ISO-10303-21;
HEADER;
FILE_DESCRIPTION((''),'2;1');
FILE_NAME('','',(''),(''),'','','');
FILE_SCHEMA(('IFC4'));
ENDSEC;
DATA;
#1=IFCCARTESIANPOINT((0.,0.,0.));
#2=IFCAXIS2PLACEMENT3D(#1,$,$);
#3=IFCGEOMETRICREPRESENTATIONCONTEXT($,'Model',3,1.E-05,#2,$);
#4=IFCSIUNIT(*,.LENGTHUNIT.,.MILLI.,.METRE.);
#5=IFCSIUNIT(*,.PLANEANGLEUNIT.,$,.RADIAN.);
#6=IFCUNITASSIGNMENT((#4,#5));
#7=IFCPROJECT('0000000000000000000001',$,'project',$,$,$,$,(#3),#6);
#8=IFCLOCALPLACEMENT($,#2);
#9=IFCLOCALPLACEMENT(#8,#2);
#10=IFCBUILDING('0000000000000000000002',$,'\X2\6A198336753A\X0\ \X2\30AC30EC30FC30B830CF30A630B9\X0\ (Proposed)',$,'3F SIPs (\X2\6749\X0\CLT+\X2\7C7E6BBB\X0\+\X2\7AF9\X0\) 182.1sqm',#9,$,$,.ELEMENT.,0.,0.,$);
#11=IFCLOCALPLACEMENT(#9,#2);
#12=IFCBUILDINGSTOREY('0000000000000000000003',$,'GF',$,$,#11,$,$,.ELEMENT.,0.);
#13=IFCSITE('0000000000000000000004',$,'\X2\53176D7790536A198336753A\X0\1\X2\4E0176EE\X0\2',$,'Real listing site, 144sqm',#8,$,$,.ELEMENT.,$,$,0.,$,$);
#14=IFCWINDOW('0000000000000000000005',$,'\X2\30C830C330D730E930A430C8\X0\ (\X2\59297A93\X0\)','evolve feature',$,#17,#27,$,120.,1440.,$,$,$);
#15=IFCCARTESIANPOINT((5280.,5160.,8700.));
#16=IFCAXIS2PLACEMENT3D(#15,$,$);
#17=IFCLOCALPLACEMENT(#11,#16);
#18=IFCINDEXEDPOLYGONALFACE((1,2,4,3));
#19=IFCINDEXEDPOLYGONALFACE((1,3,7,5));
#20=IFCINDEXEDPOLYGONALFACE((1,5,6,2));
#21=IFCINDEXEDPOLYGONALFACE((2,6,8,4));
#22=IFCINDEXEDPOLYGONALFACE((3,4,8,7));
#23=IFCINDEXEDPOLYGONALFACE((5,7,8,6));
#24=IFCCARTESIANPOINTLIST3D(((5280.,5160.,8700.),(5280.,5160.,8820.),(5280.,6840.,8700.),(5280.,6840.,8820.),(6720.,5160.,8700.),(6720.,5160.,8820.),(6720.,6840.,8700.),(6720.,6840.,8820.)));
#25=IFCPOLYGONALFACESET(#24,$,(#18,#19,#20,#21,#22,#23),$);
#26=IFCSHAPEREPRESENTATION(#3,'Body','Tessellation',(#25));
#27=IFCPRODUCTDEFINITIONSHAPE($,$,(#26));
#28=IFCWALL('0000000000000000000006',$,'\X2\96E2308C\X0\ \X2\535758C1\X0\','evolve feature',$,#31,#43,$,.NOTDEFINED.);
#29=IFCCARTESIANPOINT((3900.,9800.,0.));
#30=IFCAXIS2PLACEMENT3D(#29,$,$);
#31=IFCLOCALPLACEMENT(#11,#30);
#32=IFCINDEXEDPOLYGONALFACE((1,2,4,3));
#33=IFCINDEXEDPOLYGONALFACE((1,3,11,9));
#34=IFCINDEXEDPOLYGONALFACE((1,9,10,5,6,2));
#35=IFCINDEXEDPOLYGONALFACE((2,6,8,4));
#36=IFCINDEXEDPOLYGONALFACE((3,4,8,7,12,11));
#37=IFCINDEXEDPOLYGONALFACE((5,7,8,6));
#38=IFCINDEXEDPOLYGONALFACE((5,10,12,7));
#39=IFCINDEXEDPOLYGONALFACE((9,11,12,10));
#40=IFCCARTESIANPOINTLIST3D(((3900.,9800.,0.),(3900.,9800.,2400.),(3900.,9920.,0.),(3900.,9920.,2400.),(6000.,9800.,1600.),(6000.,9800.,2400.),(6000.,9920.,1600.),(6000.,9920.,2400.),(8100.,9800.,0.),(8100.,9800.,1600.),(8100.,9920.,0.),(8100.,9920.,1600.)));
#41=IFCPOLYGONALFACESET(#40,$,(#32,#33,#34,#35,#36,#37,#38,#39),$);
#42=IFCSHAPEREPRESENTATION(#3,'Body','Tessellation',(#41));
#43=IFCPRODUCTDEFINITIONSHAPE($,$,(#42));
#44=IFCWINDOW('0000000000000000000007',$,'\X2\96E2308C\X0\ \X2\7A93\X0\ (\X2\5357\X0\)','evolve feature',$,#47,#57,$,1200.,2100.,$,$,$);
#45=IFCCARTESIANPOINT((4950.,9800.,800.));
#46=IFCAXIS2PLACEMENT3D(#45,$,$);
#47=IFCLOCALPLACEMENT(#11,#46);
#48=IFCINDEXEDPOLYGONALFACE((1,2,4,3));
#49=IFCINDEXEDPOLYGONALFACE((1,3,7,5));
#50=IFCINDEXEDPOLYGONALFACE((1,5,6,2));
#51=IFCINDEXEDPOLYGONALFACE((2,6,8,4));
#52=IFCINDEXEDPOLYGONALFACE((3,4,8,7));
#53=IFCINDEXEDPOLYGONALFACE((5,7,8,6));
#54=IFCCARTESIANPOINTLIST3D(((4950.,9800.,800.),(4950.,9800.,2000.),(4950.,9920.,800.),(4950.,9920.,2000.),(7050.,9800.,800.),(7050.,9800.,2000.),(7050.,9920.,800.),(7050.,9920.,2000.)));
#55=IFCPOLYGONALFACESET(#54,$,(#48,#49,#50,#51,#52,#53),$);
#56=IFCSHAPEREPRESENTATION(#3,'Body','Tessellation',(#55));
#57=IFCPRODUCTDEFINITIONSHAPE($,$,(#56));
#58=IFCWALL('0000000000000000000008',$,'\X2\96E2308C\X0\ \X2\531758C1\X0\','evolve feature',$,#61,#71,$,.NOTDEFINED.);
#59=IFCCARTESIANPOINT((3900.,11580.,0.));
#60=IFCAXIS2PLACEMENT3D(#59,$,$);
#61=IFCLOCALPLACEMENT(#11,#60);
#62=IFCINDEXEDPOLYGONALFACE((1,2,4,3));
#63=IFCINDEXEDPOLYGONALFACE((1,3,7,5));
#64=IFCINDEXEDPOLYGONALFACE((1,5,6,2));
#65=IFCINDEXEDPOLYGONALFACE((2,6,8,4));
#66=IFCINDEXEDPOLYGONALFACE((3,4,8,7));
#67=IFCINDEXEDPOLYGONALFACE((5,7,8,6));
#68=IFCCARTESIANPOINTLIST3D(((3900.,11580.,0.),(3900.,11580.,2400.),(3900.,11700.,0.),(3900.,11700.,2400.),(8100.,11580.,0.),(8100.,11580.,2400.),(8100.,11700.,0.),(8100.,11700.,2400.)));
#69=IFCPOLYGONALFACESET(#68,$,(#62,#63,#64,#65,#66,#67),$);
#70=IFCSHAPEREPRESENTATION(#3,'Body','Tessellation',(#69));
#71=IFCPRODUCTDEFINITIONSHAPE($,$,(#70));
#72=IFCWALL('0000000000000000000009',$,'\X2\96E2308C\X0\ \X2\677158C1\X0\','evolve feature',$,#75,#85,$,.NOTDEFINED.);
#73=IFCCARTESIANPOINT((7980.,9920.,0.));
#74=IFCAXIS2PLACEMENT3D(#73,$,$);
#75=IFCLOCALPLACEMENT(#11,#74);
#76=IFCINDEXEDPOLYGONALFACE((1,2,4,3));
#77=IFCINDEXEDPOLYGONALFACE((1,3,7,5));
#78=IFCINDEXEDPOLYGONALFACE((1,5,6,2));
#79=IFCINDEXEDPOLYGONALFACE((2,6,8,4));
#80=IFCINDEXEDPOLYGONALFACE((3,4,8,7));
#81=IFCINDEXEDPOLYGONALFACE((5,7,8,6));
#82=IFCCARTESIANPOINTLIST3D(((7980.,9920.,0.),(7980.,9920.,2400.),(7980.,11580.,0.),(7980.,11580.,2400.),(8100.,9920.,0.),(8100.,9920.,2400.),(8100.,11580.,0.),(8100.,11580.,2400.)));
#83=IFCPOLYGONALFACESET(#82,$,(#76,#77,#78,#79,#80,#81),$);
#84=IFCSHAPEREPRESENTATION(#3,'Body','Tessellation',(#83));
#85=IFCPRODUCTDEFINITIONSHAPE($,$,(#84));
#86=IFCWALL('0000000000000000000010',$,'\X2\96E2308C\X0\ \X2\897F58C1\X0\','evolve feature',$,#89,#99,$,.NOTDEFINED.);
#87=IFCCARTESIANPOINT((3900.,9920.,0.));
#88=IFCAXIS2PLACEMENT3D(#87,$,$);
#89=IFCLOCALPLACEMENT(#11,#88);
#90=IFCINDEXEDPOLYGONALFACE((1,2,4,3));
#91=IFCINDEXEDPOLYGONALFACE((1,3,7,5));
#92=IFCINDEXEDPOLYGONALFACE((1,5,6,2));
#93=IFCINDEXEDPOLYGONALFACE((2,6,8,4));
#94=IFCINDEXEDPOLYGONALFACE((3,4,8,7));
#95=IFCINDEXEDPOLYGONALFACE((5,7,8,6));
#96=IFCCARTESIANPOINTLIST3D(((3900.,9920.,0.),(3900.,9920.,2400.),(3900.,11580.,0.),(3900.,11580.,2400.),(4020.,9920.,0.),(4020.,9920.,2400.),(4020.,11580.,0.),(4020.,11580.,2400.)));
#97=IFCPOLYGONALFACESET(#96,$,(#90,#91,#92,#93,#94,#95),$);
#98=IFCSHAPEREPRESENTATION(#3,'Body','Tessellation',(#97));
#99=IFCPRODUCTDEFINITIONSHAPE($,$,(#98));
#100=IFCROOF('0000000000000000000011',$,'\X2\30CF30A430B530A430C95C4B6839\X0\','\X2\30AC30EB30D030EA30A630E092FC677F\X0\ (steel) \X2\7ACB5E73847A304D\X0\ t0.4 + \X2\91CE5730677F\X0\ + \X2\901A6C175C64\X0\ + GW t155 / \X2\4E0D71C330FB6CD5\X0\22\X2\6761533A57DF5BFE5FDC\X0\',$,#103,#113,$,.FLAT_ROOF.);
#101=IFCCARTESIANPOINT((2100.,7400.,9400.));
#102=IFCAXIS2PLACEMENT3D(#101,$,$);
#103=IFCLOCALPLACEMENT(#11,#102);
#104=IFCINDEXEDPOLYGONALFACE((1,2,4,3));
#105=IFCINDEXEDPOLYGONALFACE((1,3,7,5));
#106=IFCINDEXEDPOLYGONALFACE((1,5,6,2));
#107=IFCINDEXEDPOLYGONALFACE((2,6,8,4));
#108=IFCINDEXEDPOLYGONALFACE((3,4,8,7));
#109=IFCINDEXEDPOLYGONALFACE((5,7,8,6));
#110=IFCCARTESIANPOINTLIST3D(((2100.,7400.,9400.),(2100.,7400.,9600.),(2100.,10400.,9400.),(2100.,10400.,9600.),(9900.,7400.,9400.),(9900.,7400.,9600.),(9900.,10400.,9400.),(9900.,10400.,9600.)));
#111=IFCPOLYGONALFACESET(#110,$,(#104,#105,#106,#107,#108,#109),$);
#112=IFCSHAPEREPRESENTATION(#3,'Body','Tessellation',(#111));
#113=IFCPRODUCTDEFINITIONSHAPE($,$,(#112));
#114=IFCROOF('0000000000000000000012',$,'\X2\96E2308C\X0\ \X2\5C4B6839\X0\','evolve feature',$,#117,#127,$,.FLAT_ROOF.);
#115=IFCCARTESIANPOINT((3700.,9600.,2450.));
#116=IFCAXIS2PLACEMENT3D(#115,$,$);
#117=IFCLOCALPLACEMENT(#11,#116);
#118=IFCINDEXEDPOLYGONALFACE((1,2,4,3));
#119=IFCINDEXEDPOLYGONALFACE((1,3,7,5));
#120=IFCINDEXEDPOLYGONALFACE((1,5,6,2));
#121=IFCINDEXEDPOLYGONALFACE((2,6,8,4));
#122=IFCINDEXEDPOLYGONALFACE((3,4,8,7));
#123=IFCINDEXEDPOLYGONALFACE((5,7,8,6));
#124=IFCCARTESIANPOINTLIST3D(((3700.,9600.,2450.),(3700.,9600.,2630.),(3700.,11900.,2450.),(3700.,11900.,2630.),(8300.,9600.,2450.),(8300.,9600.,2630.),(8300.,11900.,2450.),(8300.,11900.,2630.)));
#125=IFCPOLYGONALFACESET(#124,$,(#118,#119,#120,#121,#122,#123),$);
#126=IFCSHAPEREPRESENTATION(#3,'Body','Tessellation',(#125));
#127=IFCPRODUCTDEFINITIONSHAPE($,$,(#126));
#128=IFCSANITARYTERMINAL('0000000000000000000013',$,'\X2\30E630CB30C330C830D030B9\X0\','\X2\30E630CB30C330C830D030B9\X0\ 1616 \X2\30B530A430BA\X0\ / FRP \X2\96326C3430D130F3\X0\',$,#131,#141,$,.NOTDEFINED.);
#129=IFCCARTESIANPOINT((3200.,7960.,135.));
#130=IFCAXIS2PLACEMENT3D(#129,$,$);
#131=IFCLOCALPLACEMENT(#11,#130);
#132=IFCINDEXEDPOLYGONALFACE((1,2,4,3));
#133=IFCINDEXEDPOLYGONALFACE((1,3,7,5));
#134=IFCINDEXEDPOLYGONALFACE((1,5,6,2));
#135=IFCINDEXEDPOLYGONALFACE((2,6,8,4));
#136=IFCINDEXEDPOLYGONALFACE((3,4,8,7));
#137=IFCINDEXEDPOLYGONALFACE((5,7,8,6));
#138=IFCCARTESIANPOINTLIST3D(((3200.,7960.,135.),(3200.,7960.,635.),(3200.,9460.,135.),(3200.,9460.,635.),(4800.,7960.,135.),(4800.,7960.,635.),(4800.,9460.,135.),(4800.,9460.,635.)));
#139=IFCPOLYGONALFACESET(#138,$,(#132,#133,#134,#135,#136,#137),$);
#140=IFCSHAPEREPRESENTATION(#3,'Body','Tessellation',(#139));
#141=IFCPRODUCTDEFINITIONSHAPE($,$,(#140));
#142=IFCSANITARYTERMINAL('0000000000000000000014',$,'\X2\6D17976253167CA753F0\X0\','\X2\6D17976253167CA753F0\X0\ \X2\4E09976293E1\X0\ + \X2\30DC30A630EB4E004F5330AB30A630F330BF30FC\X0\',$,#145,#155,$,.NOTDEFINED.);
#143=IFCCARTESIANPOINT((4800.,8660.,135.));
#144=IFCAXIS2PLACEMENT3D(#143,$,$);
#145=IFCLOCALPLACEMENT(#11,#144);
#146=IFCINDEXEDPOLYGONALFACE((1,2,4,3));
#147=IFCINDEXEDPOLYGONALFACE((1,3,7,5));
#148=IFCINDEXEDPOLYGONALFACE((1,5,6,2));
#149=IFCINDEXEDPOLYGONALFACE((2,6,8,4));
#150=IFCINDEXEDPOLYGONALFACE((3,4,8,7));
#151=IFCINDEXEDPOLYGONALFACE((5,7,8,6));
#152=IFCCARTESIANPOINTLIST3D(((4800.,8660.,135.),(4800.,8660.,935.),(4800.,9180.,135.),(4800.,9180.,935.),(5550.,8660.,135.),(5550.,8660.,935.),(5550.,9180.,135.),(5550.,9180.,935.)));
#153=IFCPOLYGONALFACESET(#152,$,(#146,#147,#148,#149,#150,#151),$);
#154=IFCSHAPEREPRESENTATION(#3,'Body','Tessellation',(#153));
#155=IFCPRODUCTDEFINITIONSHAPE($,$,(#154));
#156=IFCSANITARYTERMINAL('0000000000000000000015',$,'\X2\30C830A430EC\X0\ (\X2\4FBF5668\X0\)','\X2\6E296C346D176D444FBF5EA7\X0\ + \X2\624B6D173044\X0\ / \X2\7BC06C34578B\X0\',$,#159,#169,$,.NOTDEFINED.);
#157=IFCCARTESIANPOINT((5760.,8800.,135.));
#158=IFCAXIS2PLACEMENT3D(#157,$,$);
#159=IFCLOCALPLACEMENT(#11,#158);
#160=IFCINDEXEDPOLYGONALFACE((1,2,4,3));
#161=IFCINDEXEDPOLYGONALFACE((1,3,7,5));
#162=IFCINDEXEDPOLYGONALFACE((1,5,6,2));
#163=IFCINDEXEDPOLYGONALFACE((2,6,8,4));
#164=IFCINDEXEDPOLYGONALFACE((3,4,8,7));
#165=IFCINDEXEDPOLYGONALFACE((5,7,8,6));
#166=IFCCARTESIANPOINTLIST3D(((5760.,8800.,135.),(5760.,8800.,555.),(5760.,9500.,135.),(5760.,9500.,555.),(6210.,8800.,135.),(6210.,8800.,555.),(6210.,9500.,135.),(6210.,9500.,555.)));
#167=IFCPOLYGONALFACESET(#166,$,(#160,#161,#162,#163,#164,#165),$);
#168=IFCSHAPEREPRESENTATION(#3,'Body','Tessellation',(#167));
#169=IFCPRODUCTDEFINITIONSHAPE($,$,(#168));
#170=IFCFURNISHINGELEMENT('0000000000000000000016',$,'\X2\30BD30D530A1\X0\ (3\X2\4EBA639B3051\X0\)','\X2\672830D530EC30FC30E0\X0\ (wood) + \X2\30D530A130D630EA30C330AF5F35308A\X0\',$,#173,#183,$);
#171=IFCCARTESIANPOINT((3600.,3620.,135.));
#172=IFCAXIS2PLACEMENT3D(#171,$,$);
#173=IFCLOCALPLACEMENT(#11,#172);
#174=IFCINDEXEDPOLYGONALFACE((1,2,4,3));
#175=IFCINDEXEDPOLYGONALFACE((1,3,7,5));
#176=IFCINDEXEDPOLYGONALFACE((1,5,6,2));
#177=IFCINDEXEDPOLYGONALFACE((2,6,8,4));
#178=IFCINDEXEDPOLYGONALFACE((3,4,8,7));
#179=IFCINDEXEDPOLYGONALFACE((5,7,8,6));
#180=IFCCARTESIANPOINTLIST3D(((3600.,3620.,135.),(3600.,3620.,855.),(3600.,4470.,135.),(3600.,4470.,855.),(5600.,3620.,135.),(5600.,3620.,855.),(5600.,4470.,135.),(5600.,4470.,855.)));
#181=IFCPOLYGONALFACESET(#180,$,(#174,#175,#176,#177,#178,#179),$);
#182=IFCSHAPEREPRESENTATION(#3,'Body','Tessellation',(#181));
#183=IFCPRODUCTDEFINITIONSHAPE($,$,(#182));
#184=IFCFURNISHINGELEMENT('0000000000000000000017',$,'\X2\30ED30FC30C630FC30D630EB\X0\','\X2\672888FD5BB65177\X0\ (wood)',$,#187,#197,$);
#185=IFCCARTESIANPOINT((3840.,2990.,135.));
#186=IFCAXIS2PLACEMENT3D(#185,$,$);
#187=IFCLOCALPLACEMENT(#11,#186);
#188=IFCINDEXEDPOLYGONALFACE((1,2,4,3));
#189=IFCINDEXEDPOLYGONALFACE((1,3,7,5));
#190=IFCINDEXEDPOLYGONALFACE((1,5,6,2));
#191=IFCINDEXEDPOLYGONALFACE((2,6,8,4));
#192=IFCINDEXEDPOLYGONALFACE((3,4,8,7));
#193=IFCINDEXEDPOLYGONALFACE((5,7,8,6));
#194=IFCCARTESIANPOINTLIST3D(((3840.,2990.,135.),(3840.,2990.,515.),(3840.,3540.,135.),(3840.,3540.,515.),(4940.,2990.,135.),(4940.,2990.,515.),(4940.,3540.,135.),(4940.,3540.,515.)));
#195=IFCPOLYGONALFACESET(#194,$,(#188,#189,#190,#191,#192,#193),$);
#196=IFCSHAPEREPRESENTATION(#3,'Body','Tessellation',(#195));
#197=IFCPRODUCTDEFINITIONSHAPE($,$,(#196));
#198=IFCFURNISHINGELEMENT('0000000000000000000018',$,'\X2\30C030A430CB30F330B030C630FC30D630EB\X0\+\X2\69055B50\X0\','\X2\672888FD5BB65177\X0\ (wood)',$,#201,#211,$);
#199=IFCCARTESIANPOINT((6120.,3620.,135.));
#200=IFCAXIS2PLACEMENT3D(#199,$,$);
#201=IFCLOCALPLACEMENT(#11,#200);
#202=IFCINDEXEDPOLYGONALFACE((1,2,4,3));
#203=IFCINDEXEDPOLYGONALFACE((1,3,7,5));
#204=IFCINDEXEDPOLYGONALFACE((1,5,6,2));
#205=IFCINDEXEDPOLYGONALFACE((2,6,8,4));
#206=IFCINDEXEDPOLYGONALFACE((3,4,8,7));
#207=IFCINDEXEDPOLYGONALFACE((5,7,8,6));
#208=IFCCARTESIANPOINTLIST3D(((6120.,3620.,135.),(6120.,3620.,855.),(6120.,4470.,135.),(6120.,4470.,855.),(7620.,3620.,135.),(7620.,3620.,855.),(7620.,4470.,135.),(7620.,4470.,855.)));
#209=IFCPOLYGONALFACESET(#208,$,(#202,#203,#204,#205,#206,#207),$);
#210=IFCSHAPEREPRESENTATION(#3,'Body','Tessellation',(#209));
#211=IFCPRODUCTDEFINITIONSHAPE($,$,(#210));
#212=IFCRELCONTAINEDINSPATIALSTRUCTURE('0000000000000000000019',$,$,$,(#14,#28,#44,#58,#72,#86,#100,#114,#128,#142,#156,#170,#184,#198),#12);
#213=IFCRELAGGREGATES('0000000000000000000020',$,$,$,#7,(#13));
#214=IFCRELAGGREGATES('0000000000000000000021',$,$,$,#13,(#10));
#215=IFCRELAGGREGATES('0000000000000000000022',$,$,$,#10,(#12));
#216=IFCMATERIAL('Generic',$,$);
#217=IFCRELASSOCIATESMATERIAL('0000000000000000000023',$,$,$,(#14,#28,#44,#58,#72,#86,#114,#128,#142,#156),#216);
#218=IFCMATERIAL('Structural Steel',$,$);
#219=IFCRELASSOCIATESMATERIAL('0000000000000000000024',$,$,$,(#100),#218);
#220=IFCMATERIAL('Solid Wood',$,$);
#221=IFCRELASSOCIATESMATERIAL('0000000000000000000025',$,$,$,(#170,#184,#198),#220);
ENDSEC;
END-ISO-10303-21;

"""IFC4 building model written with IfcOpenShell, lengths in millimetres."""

from ifc_helpers import new_model, si_unit, frame, frame_2d, origin, place, context, project, spatial, rectangle, extrude, material, element, fill, save


model = new_model("IFC4")

# Units and contexts
model_context = context("Model", 3, precision=1e-05, world=origin())
ifc_project = project(units=[si_unit("LENGTHUNIT", "METRE", prefix="MILLI"), si_unit("PLANEANGLEUNIT", "RADIAN")], contexts=[model_context])

# Site, building, storey
site_placement = place(None, origin())
site = spatial("IfcSite", under=ifc_project, at=site_placement, Name="北海道標茶町1丁目2", ObjectType="Real listing site, 144sqm", CompositionType="ELEMENT", RefElevation=0.0)
building_placement = place(site_placement, origin())
building = spatial("IfcBuilding", under=site, at=building_placement, Name="標茶町 ガレージハウス (Proposed)", ObjectType="3F SIPs (杉CLT+籾殻+竹) 182.1sqm", CompositionType="ELEMENT", ElevationOfRefHeight=0.0, ElevationOfTerrain=0.0)
storey_placement = place(building_placement, origin())
storey = spatial("IfcBuildingStorey", under=building, at=storey_placement, Name="GF", CompositionType="ELEMENT", Elevation=0.0)

# Shared definitions
ifc_material_1 = material(Name="Generic")

# Shared definitions
ifc_material_2 = material(Name="Solid Wood")

# Window
window_1_placement = place(storey_placement, frame((5280.0, 5160.0, 8700.0)))
element("IfcWindow", 1, at=window_1_placement, inside=storey, material=ifc_material_1, Name="トップライト (天窓)", Description="evolve feature", OverallHeight=120.0, OverallWidth=1440.0, context=model_context, shape_type="SweptSolid", body=[
    extrude(rectangle(XDim=1440.0, YDim=1680.0, at=frame_2d((720.0, 840.0))), frame((5280.0, 5160.0, 8700.0)), (0.0, 0.0, 1.0), 120.0),
])

# Wall, opening, window
wall_1_placement = place(storey_placement, frame((3900.0, 9800.0, 0.0)))
wall_1 = element("IfcWall", 2, at=wall_1_placement, inside=storey, material=ifc_material_1, Name="離れ 南壁", Description="evolve feature", PredefinedType="NOTDEFINED", context=model_context, shape_type="SweptSolid", body=[
    extrude(rectangle(XDim=4200.0, YDim=120.0, at=frame_2d((2100.0, 60.0))), frame((3900.0, 9800.0, 0.0)), (0.0, 0.0, 1.0), 2400.0),
])
opening_1_placement = place(storey_placement, frame((4950.0, 9800.0, 800.0)))
opening_1 = element("IfcOpeningElement", 3, at=opening_1_placement, cuts=wall_1, PredefinedType="NOTDEFINED", context=model_context, shape_type="SweptSolid", body=[
    extrude(rectangle(XDim=2100.0, YDim=120.0, at=frame_2d((1050.0, 60.0))), frame((4950.0, 9800.0, 800.0)), (0.0, 0.0, 1.0), 1200.0),
])
window_2_placement = place(storey_placement, frame((4950.0, 9800.0, 800.0)))
window_2 = element("IfcWindow", 4, at=window_2_placement, inside=storey, material=ifc_material_1, Name="離れ 窓 (南)", Description="evolve feature", OverallHeight=1200.0, OverallWidth=2100.0, context=model_context, shape_type="SweptSolid", body=[
    extrude(rectangle(XDim=2100.0, YDim=120.0, at=frame_2d((1050.0, 60.0))), frame((4950.0, 9800.0, 800.0)), (0.0, 0.0, 1.0), 1200.0),
])
fill(opening_1, window_2)

# Walls
wall_2_placement = place(storey_placement, frame((3900.0, 11580.0, 0.0)))
element("IfcWall", 5, at=wall_2_placement, inside=storey, material=ifc_material_1, Name="離れ 北壁", Description="evolve feature", PredefinedType="NOTDEFINED", context=model_context, shape_type="SweptSolid", body=[
    extrude(rectangle(XDim=4200.0, YDim=120.0, at=frame_2d((2100.0, 60.0))), frame((3900.0, 11580.0, 0.0)), (0.0, 0.0, 1.0), 2400.0),
])
wall_3_placement = place(storey_placement, frame((7980.0, 9920.0, 0.0)))
element("IfcWall", 6, at=wall_3_placement, inside=storey, material=ifc_material_1, Name="離れ 東壁", Description="evolve feature", PredefinedType="NOTDEFINED", context=model_context, shape_type="SweptSolid", body=[
    extrude(rectangle(XDim=120.0, YDim=1660.0, at=frame_2d((60.0, 830.0))), frame((7980.0, 9920.0, 0.0)), (0.0, 0.0, 1.0), 2400.0),
])
wall_4_placement = place(storey_placement, frame((3900.0, 9920.0, 0.0)))
element("IfcWall", 7, at=wall_4_placement, inside=storey, material=ifc_material_1, Name="離れ 西壁", Description="evolve feature", PredefinedType="NOTDEFINED", context=model_context, shape_type="SweptSolid", body=[
    extrude(rectangle(XDim=120.0, YDim=1660.0, at=frame_2d((60.0, 830.0))), frame((3900.0, 9920.0, 0.0)), (0.0, 0.0, 1.0), 2400.0),
])

# Roofs
ifc_material_3 = material(Name="Structural Steel")
roof_1_placement = place(storey_placement, frame((2100.0, 7400.0, 9400.0)))
element("IfcRoof", 8, at=roof_1_placement, inside=storey, material=ifc_material_3, Name="ハイサイド屋根", Description="ガルバリウム鋼板 (steel) 立平葺き t0.4 + 野地板 + 通気層 + GW t155 / 不燃・法22条区域対応", PredefinedType="FLAT_ROOF", context=model_context, shape_type="SweptSolid", body=[
    extrude(rectangle(XDim=7800.0, YDim=3000.0, at=frame_2d((3900.0, 1500.0))), frame((2100.0, 7400.0, 9400.0)), (0.0, 0.0, 1.0), 200.0),
])
roof_2_placement = place(storey_placement, frame((3700.0, 9600.0, 2450.0)))
element("IfcRoof", 9, at=roof_2_placement, inside=storey, material=ifc_material_1, Name="離れ 屋根", Description="evolve feature", PredefinedType="FLAT_ROOF", context=model_context, shape_type="SweptSolid", body=[
    extrude(rectangle(XDim=4600.0, YDim=2300.0, at=frame_2d((2300.0, 1150.0))), frame((3700.0, 9600.0, 2450.0)), (0.0, 0.0, 1.0), 180.0),
])

# Sanitary terminals
sanitary_terminal_1_placement = place(storey_placement, frame((3200.0, 7960.0, 135.0)))
element("IfcSanitaryTerminal", 10, at=sanitary_terminal_1_placement, inside=storey, material=ifc_material_1, Name="ユニットバス", Description="ユニットバス 1616 サイズ / FRP 防水パン", PredefinedType="NOTDEFINED", context=model_context, shape_type="SweptSolid", body=[
    extrude(rectangle(XDim=1600.0, YDim=1500.0, at=frame_2d((800.0, 750.0))), frame((3200.0, 7960.0, 135.0)), (0.0, 0.0, 1.0), 500.0),
])
sanitary_terminal_2_placement = place(storey_placement, frame((4800.0, 8660.0, 135.0)))
element("IfcSanitaryTerminal", 11, at=sanitary_terminal_2_placement, inside=storey, material=ifc_material_1, Name="洗面化粧台", Description="洗面化粧台 三面鏡 + ボウル一体カウンター", PredefinedType="NOTDEFINED", context=model_context, shape_type="SweptSolid", body=[
    extrude(rectangle(XDim=750.0, YDim=520.0, at=frame_2d((375.0, 260.0))), frame((4800.0, 8660.0, 135.0)), (0.0, 0.0, 1.0), 800.0),
])
sanitary_terminal_3_placement = place(storey_placement, frame((5760.0, 8800.0, 135.0)))
element("IfcSanitaryTerminal", 12, at=sanitary_terminal_3_placement, inside=storey, material=ifc_material_1, Name="トイレ (便器)", Description="温水洗浄便座 + 手洗い / 節水型", PredefinedType="NOTDEFINED", context=model_context, shape_type="SweptSolid", body=[
    extrude(rectangle(XDim=450.0, YDim=700.0, at=frame_2d((225.0, 350.0))), frame((5760.0, 8800.0, 135.0)), (0.0, 0.0, 1.0), 420.0),
])

# Furnishing elements
furnishing_1_placement = place(storey_placement, frame((3600.0, 3620.0, 135.0)))
element("IfcFurnishingElement", 13, at=furnishing_1_placement, inside=storey, material=ifc_material_2, Name="ソファ (3人掛け)", Description="木フレーム (wood) + ファブリック張り", context=model_context, shape_type="SweptSolid", body=[
    extrude(rectangle(XDim=2000.0, YDim=850.0, at=frame_2d((1000.0, 425.0))), frame((3600.0, 3620.0, 135.0)), (0.0, 0.0, 1.0), 720.0),
])
furnishing_2_placement = place(storey_placement, frame((3840.0, 2990.0, 135.0)))
element("IfcFurnishingElement", 14, at=furnishing_2_placement, inside=storey, material=ifc_material_2, Name="ローテーブル", Description="木製家具 (wood)", context=model_context, shape_type="SweptSolid", body=[
    extrude(rectangle(XDim=1100.0, YDim=550.0, at=frame_2d((550.0, 275.0))), frame((3840.0, 2990.0, 135.0)), (0.0, 0.0, 1.0), 380.0),
])
furnishing_3_placement = place(storey_placement, frame((6120.0, 3620.0, 135.0)))
element("IfcFurnishingElement", 15, at=furnishing_3_placement, inside=storey, material=ifc_material_2, Name="ダイニングテーブル+椅子", Description="木製家具 (wood)", context=model_context, shape_type="SweptSolid", body=[
    extrude(rectangle(XDim=1500.0, YDim=850.0, at=frame_2d((750.0, 425.0))), frame((6120.0, 3620.0, 135.0)), (0.0, 0.0, 1.0), 720.0),
])

save(model, "model.ifc")
